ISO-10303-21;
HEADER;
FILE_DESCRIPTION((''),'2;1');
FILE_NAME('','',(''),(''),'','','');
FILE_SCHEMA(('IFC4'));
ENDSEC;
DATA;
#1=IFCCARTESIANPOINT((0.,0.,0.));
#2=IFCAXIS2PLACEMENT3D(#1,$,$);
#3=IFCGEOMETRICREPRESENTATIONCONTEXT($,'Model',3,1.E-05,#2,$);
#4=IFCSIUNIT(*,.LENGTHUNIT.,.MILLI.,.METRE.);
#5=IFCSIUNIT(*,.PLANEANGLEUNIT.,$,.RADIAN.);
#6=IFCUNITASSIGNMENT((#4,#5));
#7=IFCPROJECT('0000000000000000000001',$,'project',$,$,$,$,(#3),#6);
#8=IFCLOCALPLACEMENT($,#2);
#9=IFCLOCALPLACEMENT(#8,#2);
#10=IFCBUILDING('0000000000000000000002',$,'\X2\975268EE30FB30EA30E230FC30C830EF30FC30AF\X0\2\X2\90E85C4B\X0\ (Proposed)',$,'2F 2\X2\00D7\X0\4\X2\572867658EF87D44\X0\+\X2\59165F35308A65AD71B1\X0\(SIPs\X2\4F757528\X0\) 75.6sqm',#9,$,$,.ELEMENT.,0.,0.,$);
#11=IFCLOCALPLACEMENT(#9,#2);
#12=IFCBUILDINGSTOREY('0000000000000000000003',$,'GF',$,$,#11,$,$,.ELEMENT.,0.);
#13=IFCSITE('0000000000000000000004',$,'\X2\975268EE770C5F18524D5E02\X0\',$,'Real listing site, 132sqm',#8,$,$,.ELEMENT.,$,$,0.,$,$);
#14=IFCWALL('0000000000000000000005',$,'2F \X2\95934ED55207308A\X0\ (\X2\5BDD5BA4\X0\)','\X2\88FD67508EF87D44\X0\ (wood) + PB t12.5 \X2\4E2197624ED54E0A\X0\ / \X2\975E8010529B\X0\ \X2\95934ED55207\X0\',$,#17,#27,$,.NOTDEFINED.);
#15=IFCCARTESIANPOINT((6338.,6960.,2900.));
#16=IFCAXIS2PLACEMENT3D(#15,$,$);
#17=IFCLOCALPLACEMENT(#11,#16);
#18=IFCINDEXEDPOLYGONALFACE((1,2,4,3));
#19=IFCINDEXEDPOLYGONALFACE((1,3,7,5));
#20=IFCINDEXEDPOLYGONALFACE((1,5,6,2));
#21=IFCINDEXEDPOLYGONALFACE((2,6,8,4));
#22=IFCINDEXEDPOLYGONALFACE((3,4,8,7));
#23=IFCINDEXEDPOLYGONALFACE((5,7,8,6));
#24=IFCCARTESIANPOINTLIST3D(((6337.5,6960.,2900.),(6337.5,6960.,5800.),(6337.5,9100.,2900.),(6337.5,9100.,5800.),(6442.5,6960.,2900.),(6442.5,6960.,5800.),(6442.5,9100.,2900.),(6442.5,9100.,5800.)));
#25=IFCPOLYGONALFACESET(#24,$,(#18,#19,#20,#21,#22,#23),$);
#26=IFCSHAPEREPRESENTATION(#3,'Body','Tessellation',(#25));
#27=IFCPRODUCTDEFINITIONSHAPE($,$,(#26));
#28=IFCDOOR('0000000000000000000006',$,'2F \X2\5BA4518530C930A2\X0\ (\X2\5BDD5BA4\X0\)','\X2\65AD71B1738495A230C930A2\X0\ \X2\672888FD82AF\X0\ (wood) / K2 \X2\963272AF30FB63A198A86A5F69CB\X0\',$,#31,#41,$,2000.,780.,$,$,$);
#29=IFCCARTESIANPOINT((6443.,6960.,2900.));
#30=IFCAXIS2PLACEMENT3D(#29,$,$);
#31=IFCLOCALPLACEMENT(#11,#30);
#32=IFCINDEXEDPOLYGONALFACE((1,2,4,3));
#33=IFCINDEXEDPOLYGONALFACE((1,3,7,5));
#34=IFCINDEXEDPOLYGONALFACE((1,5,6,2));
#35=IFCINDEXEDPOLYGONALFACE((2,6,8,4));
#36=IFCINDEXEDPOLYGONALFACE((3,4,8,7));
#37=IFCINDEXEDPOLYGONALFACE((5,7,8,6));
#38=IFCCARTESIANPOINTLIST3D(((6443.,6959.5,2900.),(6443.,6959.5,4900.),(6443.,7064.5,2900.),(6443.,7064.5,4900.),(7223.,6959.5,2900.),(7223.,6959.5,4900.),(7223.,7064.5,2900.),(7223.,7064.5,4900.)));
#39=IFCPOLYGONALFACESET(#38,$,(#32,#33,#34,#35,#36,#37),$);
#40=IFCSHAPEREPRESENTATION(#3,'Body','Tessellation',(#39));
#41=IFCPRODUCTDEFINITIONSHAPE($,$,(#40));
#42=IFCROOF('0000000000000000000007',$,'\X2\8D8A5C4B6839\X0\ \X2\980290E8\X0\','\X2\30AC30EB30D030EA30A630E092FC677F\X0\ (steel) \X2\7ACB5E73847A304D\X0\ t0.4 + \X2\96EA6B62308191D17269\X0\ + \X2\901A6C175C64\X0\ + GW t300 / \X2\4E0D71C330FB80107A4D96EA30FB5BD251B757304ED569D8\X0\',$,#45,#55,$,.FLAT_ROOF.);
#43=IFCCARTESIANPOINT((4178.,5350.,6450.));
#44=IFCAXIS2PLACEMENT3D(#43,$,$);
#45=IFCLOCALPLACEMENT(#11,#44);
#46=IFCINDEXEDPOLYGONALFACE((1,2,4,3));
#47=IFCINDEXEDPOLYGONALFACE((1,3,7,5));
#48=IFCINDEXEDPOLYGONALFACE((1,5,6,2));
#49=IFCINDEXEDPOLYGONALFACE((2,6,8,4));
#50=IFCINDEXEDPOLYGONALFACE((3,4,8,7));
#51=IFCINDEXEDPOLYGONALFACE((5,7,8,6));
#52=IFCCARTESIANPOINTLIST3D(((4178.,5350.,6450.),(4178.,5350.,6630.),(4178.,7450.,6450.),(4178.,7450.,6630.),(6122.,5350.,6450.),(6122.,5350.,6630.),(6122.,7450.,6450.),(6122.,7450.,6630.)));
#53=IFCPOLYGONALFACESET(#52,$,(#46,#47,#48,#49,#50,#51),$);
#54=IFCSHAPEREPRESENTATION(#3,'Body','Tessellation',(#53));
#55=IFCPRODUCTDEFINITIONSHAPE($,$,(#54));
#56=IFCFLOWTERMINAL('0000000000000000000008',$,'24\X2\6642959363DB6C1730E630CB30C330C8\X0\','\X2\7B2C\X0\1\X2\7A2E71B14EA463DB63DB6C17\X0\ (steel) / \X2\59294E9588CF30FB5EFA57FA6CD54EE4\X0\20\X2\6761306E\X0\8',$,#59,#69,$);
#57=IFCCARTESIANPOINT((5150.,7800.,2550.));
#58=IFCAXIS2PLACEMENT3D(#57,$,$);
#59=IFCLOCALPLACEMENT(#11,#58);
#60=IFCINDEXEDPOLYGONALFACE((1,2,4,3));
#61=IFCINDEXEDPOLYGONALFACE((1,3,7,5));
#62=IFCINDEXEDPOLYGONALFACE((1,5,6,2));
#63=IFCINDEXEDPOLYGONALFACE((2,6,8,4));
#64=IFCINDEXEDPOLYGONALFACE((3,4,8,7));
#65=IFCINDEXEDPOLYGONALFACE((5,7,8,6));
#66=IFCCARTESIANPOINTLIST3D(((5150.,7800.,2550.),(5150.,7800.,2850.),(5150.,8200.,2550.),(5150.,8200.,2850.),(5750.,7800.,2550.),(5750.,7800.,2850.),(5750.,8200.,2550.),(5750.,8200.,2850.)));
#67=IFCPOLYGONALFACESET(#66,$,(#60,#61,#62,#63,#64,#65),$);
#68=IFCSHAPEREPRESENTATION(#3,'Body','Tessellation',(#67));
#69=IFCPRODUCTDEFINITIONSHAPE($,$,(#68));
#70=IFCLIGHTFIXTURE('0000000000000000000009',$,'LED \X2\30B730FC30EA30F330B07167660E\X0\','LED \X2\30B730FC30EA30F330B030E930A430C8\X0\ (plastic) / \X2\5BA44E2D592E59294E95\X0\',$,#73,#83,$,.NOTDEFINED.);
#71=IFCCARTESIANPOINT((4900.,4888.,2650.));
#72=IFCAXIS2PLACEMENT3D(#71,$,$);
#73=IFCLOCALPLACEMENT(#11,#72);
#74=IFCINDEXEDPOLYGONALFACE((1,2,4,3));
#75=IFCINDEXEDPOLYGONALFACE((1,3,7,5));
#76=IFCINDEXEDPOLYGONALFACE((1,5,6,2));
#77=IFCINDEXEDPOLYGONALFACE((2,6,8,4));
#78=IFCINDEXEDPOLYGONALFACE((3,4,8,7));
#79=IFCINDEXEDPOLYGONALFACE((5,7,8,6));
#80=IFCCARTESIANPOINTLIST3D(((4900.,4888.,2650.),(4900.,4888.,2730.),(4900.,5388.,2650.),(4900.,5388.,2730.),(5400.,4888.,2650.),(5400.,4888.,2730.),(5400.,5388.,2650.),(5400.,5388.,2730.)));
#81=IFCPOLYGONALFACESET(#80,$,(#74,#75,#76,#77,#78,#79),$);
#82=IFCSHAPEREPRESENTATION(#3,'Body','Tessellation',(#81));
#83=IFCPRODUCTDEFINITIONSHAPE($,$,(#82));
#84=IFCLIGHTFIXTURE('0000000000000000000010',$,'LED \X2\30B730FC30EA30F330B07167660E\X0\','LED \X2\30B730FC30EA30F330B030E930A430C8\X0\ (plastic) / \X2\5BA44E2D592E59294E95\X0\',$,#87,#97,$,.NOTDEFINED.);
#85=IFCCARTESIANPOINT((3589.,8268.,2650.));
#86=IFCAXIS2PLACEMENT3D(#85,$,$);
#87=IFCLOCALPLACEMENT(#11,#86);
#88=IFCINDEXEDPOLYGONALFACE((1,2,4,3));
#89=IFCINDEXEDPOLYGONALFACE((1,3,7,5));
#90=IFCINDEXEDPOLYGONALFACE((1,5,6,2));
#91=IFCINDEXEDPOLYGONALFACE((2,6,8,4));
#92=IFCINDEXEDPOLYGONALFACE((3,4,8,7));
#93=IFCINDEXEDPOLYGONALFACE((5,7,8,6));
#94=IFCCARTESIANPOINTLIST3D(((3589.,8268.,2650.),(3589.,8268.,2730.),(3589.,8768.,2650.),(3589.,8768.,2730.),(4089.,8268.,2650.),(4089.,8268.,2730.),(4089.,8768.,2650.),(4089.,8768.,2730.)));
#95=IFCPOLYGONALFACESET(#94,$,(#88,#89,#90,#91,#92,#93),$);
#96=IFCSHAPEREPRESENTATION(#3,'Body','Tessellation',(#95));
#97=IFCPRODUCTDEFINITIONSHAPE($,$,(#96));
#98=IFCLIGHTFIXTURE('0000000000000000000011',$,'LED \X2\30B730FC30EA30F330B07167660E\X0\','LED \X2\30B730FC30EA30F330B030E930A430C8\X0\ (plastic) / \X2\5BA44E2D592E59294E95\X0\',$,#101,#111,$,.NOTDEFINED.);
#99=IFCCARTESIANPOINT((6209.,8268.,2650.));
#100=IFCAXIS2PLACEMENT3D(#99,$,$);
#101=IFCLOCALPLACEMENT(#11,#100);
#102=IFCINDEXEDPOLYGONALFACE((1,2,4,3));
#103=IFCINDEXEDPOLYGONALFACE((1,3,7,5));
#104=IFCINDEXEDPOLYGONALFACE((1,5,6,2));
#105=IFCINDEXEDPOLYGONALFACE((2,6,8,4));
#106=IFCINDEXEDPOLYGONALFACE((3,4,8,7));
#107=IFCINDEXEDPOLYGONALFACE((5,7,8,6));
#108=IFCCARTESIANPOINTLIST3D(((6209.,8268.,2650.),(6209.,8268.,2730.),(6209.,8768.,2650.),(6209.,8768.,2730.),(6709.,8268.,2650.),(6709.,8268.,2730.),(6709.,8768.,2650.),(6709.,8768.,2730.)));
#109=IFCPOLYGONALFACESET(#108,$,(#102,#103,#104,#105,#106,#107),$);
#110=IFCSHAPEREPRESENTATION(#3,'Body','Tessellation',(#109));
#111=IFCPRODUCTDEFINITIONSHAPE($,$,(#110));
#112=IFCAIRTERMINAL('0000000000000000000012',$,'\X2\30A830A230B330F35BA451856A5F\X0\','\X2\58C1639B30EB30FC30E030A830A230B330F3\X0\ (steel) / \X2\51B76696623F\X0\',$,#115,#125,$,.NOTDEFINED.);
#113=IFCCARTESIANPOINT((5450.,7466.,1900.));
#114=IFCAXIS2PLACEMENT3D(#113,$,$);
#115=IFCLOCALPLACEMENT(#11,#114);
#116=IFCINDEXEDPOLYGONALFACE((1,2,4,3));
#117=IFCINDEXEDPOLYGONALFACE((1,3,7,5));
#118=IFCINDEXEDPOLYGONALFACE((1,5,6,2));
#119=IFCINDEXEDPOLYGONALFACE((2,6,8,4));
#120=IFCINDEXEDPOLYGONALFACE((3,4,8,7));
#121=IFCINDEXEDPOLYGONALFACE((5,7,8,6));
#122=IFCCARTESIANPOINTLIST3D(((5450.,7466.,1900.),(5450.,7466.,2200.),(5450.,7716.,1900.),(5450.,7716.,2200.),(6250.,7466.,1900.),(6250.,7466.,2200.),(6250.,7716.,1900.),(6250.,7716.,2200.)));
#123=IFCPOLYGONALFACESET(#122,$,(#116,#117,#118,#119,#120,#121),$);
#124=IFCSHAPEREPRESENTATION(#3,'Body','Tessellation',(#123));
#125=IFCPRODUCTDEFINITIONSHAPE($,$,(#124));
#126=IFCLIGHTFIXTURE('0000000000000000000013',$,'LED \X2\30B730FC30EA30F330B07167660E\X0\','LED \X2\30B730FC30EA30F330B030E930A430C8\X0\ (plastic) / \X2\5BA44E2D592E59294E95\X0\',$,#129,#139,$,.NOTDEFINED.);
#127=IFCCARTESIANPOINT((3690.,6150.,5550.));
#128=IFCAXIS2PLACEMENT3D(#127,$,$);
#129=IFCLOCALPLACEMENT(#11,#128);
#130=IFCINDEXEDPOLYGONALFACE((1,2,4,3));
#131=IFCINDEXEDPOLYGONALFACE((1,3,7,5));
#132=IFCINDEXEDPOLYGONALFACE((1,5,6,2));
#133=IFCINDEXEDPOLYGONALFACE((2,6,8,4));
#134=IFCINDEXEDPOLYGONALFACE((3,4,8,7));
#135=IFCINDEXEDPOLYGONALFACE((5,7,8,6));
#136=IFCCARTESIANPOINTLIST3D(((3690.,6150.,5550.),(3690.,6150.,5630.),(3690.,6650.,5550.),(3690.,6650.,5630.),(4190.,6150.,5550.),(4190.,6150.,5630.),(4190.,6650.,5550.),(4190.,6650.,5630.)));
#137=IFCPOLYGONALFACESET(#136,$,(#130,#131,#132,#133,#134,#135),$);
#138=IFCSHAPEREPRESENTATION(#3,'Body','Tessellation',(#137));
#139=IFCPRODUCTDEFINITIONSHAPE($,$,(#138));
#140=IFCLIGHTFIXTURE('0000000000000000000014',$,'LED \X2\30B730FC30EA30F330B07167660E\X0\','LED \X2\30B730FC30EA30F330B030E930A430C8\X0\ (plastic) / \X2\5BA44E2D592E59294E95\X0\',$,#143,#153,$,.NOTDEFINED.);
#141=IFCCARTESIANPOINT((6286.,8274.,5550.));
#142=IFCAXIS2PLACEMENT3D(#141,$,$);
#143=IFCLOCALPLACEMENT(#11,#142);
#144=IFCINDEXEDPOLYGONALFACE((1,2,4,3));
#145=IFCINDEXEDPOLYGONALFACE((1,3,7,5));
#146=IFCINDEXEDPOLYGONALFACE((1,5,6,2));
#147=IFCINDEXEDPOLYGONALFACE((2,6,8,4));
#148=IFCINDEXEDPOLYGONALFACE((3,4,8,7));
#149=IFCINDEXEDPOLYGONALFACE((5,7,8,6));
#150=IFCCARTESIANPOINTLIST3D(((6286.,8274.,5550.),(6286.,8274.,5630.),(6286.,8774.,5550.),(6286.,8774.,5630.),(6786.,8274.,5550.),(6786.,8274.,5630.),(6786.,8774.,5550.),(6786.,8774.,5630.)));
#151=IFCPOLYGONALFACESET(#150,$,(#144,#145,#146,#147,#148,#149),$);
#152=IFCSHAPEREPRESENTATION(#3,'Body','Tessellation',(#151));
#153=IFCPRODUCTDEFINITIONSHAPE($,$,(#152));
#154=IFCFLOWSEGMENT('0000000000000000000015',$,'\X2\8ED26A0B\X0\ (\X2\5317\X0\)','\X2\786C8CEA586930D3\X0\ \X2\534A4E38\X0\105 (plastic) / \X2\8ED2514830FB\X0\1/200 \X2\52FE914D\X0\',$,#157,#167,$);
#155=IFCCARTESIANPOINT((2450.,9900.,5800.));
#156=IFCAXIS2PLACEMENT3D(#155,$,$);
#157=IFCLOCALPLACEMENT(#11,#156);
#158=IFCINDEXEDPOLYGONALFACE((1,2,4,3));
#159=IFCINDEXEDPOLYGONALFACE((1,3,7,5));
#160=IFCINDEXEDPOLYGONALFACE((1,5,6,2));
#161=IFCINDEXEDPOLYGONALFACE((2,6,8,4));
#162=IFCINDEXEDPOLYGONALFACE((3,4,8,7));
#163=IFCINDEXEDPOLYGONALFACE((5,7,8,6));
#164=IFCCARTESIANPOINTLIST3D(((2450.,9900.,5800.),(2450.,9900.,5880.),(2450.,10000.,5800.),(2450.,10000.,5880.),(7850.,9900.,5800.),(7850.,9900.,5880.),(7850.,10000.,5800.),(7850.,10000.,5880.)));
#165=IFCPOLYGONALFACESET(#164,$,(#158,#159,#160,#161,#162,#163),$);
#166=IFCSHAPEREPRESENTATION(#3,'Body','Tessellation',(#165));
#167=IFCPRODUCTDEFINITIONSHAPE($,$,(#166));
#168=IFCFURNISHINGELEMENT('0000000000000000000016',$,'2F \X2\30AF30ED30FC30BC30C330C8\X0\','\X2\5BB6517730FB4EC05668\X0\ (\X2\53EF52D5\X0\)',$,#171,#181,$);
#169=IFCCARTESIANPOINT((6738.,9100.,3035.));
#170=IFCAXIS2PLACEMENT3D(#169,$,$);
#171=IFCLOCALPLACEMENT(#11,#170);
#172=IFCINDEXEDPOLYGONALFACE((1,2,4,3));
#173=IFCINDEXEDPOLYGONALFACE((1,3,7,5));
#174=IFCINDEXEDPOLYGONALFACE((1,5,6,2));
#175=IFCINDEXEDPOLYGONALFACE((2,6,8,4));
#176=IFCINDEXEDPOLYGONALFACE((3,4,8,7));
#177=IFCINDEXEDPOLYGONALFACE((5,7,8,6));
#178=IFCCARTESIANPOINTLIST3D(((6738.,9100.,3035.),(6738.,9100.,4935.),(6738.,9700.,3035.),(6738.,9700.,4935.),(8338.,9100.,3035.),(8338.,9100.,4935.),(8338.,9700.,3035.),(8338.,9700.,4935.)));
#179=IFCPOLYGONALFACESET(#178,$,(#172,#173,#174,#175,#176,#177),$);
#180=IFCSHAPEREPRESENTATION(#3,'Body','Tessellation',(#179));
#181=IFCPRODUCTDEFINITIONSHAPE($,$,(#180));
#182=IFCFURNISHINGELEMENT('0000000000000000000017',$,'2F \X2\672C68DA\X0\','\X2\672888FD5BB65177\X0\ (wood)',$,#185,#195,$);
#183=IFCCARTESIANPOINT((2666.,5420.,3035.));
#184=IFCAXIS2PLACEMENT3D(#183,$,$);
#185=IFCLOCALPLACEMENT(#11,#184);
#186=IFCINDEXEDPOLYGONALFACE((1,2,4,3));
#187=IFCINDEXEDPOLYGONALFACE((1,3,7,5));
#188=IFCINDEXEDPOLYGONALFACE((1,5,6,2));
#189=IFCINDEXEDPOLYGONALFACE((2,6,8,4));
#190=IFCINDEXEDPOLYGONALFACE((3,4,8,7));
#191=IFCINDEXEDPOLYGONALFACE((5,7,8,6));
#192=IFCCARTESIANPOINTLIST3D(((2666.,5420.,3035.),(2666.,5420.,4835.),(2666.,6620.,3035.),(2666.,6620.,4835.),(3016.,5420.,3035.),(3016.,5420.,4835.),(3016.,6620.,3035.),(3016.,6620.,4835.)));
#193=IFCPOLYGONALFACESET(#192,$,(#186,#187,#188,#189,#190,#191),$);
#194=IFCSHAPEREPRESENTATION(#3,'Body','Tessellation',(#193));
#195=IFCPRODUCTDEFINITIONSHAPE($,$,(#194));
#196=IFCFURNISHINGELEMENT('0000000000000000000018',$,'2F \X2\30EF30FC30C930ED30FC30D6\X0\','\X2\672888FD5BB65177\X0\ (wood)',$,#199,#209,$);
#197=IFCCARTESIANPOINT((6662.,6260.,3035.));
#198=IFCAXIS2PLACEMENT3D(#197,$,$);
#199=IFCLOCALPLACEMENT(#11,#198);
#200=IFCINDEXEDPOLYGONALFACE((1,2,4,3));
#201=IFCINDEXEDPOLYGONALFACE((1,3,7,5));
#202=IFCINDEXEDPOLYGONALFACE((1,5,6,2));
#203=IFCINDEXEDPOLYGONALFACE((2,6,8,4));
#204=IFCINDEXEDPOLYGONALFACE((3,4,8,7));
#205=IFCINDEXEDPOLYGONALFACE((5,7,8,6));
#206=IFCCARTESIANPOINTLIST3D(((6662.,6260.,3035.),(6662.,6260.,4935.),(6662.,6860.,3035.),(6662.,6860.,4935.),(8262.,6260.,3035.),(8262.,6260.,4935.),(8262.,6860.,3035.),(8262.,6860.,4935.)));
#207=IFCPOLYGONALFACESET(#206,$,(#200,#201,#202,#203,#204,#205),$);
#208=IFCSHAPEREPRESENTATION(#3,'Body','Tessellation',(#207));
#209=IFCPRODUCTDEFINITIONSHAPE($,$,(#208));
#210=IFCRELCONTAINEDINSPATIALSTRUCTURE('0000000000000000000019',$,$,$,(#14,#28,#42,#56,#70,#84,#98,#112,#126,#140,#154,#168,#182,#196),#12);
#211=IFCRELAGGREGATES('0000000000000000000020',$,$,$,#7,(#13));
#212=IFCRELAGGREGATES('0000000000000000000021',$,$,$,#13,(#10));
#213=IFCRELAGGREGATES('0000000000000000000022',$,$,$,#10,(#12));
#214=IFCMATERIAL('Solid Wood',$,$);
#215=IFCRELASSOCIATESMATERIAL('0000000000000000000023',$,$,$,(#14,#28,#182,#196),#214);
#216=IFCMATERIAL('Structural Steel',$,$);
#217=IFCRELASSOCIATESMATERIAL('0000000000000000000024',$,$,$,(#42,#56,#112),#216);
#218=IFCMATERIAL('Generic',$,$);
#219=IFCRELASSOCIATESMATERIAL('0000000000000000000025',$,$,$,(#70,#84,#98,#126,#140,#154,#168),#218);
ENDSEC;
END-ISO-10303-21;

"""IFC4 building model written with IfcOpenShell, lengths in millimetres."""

from ifc_helpers import new_model, si_unit, frame, frame_2d, origin, place, context, project, spatial, rectangle, extrude, material, element, save


model = new_model("IFC4")

# Units and contexts
model_context = context("Model", 3, precision=1e-05, world=origin())
ifc_project = project(units=[si_unit("LENGTHUNIT", "METRE", prefix="MILLI"), si_unit("PLANEANGLEUNIT", "RADIAN")], contexts=[model_context])

# Site, building, storey
site_placement = place(None, origin())
site = spatial("IfcSite", under=ifc_project, at=site_placement, Name="青森県弘前市", ObjectType="Real listing site, 132sqm", CompositionType="ELEMENT", RefElevation=0.0)
building_placement = place(site_placement, origin())
building = spatial("IfcBuilding", under=site, at=building_placement, Name="青森・リモートワーク2部屋 (Proposed)", ObjectType="2F 2×4在来軸組+外張り断熱(SIPs併用) 75.6sqm", CompositionType="ELEMENT", ElevationOfRefHeight=0.0, ElevationOfTerrain=0.0)
storey_placement = place(building_placement, origin())
storey = spatial("IfcBuildingStorey", under=building, at=storey_placement, Name="GF", CompositionType="ELEMENT", Elevation=0.0)

# Shared definitions
ifc_material_1 = material(Name="Solid Wood")

# Wall
wall_1_placement = place(storey_placement, frame((6338.0, 6960.0, 2900.0)))
element("IfcWall", 1, at=wall_1_placement, inside=storey, material=ifc_material_1, Name="2F 間仕切り (寝室)", Description="製材軸組 (wood) + PB t12.5 両面仕上 / 非耐力 間仕切", PredefinedType="NOTDEFINED", context=model_context, shape_type="SweptSolid", body=[
    extrude(rectangle(XDim=105.0, YDim=2140.0, at=frame_2d((52.0, 1070.0))), frame((6338.0, 6960.0, 2900.0)), (0.0, 0.0, 1.0), 2900.0),
])

# Door
door_placement = place(storey_placement, frame((6443.0, 6960.0, 2900.0)))
element("IfcDoor", 2, at=door_placement, inside=storey, material=ifc_material_1, Name="2F 室内ドア (寝室)", Description="断熱玄関ドア 木製芯 (wood) / K2 防犯・採風機構", OverallHeight=2000.0, OverallWidth=780.0, context=model_context, shape_type="SweptSolid", body=[
    extrude(rectangle(XDim=780.0, YDim=105.0, at=frame_2d((390.0, 52.0))), frame((6443.0, 6960.0, 2900.0)), (0.0, 0.0, 1.0), 2000.0),
])

# Roof
ifc_material_2 = material(Name="Structural Steel")
roof_placement = place(storey_placement, frame((4178.0, 5350.0, 6450.0)))
element("IfcRoof", 3, at=roof_placement, inside=storey, material=ifc_material_2, Name="越屋根 頂部", Description="ガルバリウム鋼板 (steel) 立平葺き t0.4 + 雪止め金物 + 通気層 + GW t300 / 不燃・耐積雪・寒冷地仕様", PredefinedType="FLAT_ROOF", context=model_context, shape_type="SweptSolid", body=[
    extrude(rectangle(XDim=1944.0, YDim=2100.0, at=frame_2d((972.0, 1050.0))), frame((4178.0, 5350.0, 6450.0)), (0.0, 0.0, 1.0), 180.0),
])

# Flow terminal
flow_terminal_placement = place(storey_placement, frame((5150.0, 7800.0, 2550.0)))
element("IfcFlowTerminal", 4, at=flow_terminal_placement, inside=storey, material=ifc_material_2, Name="24時間換気ユニット", Description="第1種熱交換換気 (steel) / 天井裏・建基法令20条の8", context=model_context, shape_type="SweptSolid", body=[
    extrude(rectangle(XDim=600.0, YDim=400.0, at=frame_2d((300.0, 200.0))), frame((5150.0, 7800.0, 2550.0)), (0.0, 0.0, 1.0), 300.0),
])

# Light fixtures
ifc_material_3 = material(Name="Generic")
light_fixture_1_placement = place(storey_placement, frame((4900.0, 4888.0, 2650.0)))
element("IfcLightFixture", 5, at=light_fixture_1_placement, inside=storey, material=ifc_material_3, Name="LED シーリング照明", Description="LED シーリングライト (plastic) / 室中央天井", PredefinedType="NOTDEFINED", context=model_context, shape_type="SweptSolid", body=[
    extrude(rectangle(XDim=500.0, YDim=500.0, at=frame_2d((250.0, 250.0))), frame((4900.0, 4888.0, 2650.0)), (0.0, 0.0, 1.0), 80.0),
])
light_fixture_2_placement = place(storey_placement, frame((3589.0, 8268.0, 2650.0)))
element("IfcLightFixture", 6, at=light_fixture_2_placement, inside=storey, material=ifc_material_3, Name="LED シーリング照明", Description="LED シーリングライト (plastic) / 室中央天井", PredefinedType="NOTDEFINED", context=model_context, shape_type="SweptSolid", body=[
    extrude(rectangle(XDim=500.0, YDim=500.0, at=frame_2d((250.0, 250.0))), frame((3589.0, 8268.0, 2650.0)), (0.0, 0.0, 1.0), 80.0),
])
light_fixture_3_placement = place(storey_placement, frame((6209.0, 8268.0, 2650.0)))
element("IfcLightFixture", 7, at=light_fixture_3_placement, inside=storey, material=ifc_material_3, Name="LED シーリング照明", Description="LED シーリングライト (plastic) / 室中央天井", PredefinedType="NOTDEFINED", context=model_context, shape_type="SweptSolid", body=[
    extrude(rectangle(XDim=500.0, YDim=500.0, at=frame_2d((250.0, 250.0))), frame((6209.0, 8268.0, 2650.0)), (0.0, 0.0, 1.0), 80.0),
])

# Air terminal
air_terminal_placement = place(storey_placement, frame((5450.0, 7466.0, 1900.0)))
element("IfcAirTerminal", 8, at=air_terminal_placement, inside=storey, material=ifc_material_2, Name="エアコン室内機", Description="壁掛ルームエアコン (steel) / 冷暖房", PredefinedType="NOTDEFINED", context=model_context, shape_type="SweptSolid", body=[
    extrude(rectangle(XDim=800.0, YDim=250.0, at=frame_2d((400.0, 125.0))), frame((5450.0, 7466.0, 1900.0)), (0.0, 0.0, 1.0), 300.0),
])

# Light fixtures
light_fixture_4_placement = place(storey_placement, frame((3690.0, 6150.0, 5550.0)))
element("IfcLightFixture", 9, at=light_fixture_4_placement, inside=storey, material=ifc_material_3, Name="LED シーリング照明", Description="LED シーリングライト (plastic) / 室中央天井", PredefinedType="NOTDEFINED", context=model_context, shape_type="SweptSolid", body=[
    extrude(rectangle(XDim=500.0, YDim=500.0, at=frame_2d((250.0, 250.0))), frame((3690.0, 6150.0, 5550.0)), (0.0, 0.0, 1.0), 80.0),
])
light_fixture_5_placement = place(storey_placement, frame((6286.0, 8274.0, 5550.0)))
element("IfcLightFixture", 10, at=light_fixture_5_placement, inside=storey, material=ifc_material_3, Name="LED シーリング照明", Description="LED シーリングライト (plastic) / 室中央天井", PredefinedType="NOTDEFINED", context=model_context, shape_type="SweptSolid", body=[
    extrude(rectangle(XDim=500.0, YDim=500.0, at=frame_2d((250.0, 250.0))), frame((6286.0, 8274.0, 5550.0)), (0.0, 0.0, 1.0), 80.0),
])

# Flow segment
flow_segment_placement = place(storey_placement, frame((2450.0, 9900.0, 5800.0)))
element("IfcFlowSegment", 11, at=flow_segment_placement, inside=storey, material=ifc_material_3, Name="軒樋 (北)", Description="硬質塩ビ 半丸105 (plastic) / 軒先・1/200 勾配", context=model_context, shape_type="SweptSolid", body=[
    extrude(rectangle(XDim=5400.0, YDim=100.0, at=frame_2d((2700.0, 50.0))), frame((2450.0, 9900.0, 5800.0)), (0.0, 0.0, 1.0), 80.0),
])

# Furnishing elements
furnishing_1_placement = place(storey_placement, frame((6738.0, 9100.0, 3035.0)))
element("IfcFurnishingElement", 12, at=furnishing_1_placement, inside=storey, material=ifc_material_3, Name="2F クローゼット", Description="家具・什器 (可動)", context=model_context, shape_type="SweptSolid", body=[
    extrude(rectangle(XDim=1600.0, YDim=600.0, at=frame_2d((800.0, 300.0))), frame((6738.0, 9100.0, 3035.0)), (0.0, 0.0, 1.0), 1900.0),
])
furnishing_2_placement = place(storey_placement, frame((2666.0, 5420.0, 3035.0)))
element("IfcFurnishingElement", 13, at=furnishing_2_placement, inside=storey, material=ifc_material_1, Name="2F 本棚", Description="木製家具 (wood)", context=model_context, shape_type="SweptSolid", body=[
    extrude(rectangle(XDim=350.0, YDim=1200.0, at=frame_2d((175.0, 600.0))), frame((2666.0, 5420.0, 3035.0)), (0.0, 0.0, 1.0), 1800.0),
])
furnishing_3_placement = place(storey_placement, frame((6662.0, 6260.0, 3035.0)))
element("IfcFurnishingElement", 14, at=furnishing_3_placement, inside=storey, material=ifc_material_1, Name="2F ワードローブ", Description="木製家具 (wood)", context=model_context, shape_type="SweptSolid", body=[
    extrude(rectangle(XDim=1600.0, YDim=600.0, at=frame_2d((800.0, 300.0))), frame((6662.0, 6260.0, 3035.0)), (0.0, 0.0, 1.0), 1900.0),
])

save(model, "model.ifc")
